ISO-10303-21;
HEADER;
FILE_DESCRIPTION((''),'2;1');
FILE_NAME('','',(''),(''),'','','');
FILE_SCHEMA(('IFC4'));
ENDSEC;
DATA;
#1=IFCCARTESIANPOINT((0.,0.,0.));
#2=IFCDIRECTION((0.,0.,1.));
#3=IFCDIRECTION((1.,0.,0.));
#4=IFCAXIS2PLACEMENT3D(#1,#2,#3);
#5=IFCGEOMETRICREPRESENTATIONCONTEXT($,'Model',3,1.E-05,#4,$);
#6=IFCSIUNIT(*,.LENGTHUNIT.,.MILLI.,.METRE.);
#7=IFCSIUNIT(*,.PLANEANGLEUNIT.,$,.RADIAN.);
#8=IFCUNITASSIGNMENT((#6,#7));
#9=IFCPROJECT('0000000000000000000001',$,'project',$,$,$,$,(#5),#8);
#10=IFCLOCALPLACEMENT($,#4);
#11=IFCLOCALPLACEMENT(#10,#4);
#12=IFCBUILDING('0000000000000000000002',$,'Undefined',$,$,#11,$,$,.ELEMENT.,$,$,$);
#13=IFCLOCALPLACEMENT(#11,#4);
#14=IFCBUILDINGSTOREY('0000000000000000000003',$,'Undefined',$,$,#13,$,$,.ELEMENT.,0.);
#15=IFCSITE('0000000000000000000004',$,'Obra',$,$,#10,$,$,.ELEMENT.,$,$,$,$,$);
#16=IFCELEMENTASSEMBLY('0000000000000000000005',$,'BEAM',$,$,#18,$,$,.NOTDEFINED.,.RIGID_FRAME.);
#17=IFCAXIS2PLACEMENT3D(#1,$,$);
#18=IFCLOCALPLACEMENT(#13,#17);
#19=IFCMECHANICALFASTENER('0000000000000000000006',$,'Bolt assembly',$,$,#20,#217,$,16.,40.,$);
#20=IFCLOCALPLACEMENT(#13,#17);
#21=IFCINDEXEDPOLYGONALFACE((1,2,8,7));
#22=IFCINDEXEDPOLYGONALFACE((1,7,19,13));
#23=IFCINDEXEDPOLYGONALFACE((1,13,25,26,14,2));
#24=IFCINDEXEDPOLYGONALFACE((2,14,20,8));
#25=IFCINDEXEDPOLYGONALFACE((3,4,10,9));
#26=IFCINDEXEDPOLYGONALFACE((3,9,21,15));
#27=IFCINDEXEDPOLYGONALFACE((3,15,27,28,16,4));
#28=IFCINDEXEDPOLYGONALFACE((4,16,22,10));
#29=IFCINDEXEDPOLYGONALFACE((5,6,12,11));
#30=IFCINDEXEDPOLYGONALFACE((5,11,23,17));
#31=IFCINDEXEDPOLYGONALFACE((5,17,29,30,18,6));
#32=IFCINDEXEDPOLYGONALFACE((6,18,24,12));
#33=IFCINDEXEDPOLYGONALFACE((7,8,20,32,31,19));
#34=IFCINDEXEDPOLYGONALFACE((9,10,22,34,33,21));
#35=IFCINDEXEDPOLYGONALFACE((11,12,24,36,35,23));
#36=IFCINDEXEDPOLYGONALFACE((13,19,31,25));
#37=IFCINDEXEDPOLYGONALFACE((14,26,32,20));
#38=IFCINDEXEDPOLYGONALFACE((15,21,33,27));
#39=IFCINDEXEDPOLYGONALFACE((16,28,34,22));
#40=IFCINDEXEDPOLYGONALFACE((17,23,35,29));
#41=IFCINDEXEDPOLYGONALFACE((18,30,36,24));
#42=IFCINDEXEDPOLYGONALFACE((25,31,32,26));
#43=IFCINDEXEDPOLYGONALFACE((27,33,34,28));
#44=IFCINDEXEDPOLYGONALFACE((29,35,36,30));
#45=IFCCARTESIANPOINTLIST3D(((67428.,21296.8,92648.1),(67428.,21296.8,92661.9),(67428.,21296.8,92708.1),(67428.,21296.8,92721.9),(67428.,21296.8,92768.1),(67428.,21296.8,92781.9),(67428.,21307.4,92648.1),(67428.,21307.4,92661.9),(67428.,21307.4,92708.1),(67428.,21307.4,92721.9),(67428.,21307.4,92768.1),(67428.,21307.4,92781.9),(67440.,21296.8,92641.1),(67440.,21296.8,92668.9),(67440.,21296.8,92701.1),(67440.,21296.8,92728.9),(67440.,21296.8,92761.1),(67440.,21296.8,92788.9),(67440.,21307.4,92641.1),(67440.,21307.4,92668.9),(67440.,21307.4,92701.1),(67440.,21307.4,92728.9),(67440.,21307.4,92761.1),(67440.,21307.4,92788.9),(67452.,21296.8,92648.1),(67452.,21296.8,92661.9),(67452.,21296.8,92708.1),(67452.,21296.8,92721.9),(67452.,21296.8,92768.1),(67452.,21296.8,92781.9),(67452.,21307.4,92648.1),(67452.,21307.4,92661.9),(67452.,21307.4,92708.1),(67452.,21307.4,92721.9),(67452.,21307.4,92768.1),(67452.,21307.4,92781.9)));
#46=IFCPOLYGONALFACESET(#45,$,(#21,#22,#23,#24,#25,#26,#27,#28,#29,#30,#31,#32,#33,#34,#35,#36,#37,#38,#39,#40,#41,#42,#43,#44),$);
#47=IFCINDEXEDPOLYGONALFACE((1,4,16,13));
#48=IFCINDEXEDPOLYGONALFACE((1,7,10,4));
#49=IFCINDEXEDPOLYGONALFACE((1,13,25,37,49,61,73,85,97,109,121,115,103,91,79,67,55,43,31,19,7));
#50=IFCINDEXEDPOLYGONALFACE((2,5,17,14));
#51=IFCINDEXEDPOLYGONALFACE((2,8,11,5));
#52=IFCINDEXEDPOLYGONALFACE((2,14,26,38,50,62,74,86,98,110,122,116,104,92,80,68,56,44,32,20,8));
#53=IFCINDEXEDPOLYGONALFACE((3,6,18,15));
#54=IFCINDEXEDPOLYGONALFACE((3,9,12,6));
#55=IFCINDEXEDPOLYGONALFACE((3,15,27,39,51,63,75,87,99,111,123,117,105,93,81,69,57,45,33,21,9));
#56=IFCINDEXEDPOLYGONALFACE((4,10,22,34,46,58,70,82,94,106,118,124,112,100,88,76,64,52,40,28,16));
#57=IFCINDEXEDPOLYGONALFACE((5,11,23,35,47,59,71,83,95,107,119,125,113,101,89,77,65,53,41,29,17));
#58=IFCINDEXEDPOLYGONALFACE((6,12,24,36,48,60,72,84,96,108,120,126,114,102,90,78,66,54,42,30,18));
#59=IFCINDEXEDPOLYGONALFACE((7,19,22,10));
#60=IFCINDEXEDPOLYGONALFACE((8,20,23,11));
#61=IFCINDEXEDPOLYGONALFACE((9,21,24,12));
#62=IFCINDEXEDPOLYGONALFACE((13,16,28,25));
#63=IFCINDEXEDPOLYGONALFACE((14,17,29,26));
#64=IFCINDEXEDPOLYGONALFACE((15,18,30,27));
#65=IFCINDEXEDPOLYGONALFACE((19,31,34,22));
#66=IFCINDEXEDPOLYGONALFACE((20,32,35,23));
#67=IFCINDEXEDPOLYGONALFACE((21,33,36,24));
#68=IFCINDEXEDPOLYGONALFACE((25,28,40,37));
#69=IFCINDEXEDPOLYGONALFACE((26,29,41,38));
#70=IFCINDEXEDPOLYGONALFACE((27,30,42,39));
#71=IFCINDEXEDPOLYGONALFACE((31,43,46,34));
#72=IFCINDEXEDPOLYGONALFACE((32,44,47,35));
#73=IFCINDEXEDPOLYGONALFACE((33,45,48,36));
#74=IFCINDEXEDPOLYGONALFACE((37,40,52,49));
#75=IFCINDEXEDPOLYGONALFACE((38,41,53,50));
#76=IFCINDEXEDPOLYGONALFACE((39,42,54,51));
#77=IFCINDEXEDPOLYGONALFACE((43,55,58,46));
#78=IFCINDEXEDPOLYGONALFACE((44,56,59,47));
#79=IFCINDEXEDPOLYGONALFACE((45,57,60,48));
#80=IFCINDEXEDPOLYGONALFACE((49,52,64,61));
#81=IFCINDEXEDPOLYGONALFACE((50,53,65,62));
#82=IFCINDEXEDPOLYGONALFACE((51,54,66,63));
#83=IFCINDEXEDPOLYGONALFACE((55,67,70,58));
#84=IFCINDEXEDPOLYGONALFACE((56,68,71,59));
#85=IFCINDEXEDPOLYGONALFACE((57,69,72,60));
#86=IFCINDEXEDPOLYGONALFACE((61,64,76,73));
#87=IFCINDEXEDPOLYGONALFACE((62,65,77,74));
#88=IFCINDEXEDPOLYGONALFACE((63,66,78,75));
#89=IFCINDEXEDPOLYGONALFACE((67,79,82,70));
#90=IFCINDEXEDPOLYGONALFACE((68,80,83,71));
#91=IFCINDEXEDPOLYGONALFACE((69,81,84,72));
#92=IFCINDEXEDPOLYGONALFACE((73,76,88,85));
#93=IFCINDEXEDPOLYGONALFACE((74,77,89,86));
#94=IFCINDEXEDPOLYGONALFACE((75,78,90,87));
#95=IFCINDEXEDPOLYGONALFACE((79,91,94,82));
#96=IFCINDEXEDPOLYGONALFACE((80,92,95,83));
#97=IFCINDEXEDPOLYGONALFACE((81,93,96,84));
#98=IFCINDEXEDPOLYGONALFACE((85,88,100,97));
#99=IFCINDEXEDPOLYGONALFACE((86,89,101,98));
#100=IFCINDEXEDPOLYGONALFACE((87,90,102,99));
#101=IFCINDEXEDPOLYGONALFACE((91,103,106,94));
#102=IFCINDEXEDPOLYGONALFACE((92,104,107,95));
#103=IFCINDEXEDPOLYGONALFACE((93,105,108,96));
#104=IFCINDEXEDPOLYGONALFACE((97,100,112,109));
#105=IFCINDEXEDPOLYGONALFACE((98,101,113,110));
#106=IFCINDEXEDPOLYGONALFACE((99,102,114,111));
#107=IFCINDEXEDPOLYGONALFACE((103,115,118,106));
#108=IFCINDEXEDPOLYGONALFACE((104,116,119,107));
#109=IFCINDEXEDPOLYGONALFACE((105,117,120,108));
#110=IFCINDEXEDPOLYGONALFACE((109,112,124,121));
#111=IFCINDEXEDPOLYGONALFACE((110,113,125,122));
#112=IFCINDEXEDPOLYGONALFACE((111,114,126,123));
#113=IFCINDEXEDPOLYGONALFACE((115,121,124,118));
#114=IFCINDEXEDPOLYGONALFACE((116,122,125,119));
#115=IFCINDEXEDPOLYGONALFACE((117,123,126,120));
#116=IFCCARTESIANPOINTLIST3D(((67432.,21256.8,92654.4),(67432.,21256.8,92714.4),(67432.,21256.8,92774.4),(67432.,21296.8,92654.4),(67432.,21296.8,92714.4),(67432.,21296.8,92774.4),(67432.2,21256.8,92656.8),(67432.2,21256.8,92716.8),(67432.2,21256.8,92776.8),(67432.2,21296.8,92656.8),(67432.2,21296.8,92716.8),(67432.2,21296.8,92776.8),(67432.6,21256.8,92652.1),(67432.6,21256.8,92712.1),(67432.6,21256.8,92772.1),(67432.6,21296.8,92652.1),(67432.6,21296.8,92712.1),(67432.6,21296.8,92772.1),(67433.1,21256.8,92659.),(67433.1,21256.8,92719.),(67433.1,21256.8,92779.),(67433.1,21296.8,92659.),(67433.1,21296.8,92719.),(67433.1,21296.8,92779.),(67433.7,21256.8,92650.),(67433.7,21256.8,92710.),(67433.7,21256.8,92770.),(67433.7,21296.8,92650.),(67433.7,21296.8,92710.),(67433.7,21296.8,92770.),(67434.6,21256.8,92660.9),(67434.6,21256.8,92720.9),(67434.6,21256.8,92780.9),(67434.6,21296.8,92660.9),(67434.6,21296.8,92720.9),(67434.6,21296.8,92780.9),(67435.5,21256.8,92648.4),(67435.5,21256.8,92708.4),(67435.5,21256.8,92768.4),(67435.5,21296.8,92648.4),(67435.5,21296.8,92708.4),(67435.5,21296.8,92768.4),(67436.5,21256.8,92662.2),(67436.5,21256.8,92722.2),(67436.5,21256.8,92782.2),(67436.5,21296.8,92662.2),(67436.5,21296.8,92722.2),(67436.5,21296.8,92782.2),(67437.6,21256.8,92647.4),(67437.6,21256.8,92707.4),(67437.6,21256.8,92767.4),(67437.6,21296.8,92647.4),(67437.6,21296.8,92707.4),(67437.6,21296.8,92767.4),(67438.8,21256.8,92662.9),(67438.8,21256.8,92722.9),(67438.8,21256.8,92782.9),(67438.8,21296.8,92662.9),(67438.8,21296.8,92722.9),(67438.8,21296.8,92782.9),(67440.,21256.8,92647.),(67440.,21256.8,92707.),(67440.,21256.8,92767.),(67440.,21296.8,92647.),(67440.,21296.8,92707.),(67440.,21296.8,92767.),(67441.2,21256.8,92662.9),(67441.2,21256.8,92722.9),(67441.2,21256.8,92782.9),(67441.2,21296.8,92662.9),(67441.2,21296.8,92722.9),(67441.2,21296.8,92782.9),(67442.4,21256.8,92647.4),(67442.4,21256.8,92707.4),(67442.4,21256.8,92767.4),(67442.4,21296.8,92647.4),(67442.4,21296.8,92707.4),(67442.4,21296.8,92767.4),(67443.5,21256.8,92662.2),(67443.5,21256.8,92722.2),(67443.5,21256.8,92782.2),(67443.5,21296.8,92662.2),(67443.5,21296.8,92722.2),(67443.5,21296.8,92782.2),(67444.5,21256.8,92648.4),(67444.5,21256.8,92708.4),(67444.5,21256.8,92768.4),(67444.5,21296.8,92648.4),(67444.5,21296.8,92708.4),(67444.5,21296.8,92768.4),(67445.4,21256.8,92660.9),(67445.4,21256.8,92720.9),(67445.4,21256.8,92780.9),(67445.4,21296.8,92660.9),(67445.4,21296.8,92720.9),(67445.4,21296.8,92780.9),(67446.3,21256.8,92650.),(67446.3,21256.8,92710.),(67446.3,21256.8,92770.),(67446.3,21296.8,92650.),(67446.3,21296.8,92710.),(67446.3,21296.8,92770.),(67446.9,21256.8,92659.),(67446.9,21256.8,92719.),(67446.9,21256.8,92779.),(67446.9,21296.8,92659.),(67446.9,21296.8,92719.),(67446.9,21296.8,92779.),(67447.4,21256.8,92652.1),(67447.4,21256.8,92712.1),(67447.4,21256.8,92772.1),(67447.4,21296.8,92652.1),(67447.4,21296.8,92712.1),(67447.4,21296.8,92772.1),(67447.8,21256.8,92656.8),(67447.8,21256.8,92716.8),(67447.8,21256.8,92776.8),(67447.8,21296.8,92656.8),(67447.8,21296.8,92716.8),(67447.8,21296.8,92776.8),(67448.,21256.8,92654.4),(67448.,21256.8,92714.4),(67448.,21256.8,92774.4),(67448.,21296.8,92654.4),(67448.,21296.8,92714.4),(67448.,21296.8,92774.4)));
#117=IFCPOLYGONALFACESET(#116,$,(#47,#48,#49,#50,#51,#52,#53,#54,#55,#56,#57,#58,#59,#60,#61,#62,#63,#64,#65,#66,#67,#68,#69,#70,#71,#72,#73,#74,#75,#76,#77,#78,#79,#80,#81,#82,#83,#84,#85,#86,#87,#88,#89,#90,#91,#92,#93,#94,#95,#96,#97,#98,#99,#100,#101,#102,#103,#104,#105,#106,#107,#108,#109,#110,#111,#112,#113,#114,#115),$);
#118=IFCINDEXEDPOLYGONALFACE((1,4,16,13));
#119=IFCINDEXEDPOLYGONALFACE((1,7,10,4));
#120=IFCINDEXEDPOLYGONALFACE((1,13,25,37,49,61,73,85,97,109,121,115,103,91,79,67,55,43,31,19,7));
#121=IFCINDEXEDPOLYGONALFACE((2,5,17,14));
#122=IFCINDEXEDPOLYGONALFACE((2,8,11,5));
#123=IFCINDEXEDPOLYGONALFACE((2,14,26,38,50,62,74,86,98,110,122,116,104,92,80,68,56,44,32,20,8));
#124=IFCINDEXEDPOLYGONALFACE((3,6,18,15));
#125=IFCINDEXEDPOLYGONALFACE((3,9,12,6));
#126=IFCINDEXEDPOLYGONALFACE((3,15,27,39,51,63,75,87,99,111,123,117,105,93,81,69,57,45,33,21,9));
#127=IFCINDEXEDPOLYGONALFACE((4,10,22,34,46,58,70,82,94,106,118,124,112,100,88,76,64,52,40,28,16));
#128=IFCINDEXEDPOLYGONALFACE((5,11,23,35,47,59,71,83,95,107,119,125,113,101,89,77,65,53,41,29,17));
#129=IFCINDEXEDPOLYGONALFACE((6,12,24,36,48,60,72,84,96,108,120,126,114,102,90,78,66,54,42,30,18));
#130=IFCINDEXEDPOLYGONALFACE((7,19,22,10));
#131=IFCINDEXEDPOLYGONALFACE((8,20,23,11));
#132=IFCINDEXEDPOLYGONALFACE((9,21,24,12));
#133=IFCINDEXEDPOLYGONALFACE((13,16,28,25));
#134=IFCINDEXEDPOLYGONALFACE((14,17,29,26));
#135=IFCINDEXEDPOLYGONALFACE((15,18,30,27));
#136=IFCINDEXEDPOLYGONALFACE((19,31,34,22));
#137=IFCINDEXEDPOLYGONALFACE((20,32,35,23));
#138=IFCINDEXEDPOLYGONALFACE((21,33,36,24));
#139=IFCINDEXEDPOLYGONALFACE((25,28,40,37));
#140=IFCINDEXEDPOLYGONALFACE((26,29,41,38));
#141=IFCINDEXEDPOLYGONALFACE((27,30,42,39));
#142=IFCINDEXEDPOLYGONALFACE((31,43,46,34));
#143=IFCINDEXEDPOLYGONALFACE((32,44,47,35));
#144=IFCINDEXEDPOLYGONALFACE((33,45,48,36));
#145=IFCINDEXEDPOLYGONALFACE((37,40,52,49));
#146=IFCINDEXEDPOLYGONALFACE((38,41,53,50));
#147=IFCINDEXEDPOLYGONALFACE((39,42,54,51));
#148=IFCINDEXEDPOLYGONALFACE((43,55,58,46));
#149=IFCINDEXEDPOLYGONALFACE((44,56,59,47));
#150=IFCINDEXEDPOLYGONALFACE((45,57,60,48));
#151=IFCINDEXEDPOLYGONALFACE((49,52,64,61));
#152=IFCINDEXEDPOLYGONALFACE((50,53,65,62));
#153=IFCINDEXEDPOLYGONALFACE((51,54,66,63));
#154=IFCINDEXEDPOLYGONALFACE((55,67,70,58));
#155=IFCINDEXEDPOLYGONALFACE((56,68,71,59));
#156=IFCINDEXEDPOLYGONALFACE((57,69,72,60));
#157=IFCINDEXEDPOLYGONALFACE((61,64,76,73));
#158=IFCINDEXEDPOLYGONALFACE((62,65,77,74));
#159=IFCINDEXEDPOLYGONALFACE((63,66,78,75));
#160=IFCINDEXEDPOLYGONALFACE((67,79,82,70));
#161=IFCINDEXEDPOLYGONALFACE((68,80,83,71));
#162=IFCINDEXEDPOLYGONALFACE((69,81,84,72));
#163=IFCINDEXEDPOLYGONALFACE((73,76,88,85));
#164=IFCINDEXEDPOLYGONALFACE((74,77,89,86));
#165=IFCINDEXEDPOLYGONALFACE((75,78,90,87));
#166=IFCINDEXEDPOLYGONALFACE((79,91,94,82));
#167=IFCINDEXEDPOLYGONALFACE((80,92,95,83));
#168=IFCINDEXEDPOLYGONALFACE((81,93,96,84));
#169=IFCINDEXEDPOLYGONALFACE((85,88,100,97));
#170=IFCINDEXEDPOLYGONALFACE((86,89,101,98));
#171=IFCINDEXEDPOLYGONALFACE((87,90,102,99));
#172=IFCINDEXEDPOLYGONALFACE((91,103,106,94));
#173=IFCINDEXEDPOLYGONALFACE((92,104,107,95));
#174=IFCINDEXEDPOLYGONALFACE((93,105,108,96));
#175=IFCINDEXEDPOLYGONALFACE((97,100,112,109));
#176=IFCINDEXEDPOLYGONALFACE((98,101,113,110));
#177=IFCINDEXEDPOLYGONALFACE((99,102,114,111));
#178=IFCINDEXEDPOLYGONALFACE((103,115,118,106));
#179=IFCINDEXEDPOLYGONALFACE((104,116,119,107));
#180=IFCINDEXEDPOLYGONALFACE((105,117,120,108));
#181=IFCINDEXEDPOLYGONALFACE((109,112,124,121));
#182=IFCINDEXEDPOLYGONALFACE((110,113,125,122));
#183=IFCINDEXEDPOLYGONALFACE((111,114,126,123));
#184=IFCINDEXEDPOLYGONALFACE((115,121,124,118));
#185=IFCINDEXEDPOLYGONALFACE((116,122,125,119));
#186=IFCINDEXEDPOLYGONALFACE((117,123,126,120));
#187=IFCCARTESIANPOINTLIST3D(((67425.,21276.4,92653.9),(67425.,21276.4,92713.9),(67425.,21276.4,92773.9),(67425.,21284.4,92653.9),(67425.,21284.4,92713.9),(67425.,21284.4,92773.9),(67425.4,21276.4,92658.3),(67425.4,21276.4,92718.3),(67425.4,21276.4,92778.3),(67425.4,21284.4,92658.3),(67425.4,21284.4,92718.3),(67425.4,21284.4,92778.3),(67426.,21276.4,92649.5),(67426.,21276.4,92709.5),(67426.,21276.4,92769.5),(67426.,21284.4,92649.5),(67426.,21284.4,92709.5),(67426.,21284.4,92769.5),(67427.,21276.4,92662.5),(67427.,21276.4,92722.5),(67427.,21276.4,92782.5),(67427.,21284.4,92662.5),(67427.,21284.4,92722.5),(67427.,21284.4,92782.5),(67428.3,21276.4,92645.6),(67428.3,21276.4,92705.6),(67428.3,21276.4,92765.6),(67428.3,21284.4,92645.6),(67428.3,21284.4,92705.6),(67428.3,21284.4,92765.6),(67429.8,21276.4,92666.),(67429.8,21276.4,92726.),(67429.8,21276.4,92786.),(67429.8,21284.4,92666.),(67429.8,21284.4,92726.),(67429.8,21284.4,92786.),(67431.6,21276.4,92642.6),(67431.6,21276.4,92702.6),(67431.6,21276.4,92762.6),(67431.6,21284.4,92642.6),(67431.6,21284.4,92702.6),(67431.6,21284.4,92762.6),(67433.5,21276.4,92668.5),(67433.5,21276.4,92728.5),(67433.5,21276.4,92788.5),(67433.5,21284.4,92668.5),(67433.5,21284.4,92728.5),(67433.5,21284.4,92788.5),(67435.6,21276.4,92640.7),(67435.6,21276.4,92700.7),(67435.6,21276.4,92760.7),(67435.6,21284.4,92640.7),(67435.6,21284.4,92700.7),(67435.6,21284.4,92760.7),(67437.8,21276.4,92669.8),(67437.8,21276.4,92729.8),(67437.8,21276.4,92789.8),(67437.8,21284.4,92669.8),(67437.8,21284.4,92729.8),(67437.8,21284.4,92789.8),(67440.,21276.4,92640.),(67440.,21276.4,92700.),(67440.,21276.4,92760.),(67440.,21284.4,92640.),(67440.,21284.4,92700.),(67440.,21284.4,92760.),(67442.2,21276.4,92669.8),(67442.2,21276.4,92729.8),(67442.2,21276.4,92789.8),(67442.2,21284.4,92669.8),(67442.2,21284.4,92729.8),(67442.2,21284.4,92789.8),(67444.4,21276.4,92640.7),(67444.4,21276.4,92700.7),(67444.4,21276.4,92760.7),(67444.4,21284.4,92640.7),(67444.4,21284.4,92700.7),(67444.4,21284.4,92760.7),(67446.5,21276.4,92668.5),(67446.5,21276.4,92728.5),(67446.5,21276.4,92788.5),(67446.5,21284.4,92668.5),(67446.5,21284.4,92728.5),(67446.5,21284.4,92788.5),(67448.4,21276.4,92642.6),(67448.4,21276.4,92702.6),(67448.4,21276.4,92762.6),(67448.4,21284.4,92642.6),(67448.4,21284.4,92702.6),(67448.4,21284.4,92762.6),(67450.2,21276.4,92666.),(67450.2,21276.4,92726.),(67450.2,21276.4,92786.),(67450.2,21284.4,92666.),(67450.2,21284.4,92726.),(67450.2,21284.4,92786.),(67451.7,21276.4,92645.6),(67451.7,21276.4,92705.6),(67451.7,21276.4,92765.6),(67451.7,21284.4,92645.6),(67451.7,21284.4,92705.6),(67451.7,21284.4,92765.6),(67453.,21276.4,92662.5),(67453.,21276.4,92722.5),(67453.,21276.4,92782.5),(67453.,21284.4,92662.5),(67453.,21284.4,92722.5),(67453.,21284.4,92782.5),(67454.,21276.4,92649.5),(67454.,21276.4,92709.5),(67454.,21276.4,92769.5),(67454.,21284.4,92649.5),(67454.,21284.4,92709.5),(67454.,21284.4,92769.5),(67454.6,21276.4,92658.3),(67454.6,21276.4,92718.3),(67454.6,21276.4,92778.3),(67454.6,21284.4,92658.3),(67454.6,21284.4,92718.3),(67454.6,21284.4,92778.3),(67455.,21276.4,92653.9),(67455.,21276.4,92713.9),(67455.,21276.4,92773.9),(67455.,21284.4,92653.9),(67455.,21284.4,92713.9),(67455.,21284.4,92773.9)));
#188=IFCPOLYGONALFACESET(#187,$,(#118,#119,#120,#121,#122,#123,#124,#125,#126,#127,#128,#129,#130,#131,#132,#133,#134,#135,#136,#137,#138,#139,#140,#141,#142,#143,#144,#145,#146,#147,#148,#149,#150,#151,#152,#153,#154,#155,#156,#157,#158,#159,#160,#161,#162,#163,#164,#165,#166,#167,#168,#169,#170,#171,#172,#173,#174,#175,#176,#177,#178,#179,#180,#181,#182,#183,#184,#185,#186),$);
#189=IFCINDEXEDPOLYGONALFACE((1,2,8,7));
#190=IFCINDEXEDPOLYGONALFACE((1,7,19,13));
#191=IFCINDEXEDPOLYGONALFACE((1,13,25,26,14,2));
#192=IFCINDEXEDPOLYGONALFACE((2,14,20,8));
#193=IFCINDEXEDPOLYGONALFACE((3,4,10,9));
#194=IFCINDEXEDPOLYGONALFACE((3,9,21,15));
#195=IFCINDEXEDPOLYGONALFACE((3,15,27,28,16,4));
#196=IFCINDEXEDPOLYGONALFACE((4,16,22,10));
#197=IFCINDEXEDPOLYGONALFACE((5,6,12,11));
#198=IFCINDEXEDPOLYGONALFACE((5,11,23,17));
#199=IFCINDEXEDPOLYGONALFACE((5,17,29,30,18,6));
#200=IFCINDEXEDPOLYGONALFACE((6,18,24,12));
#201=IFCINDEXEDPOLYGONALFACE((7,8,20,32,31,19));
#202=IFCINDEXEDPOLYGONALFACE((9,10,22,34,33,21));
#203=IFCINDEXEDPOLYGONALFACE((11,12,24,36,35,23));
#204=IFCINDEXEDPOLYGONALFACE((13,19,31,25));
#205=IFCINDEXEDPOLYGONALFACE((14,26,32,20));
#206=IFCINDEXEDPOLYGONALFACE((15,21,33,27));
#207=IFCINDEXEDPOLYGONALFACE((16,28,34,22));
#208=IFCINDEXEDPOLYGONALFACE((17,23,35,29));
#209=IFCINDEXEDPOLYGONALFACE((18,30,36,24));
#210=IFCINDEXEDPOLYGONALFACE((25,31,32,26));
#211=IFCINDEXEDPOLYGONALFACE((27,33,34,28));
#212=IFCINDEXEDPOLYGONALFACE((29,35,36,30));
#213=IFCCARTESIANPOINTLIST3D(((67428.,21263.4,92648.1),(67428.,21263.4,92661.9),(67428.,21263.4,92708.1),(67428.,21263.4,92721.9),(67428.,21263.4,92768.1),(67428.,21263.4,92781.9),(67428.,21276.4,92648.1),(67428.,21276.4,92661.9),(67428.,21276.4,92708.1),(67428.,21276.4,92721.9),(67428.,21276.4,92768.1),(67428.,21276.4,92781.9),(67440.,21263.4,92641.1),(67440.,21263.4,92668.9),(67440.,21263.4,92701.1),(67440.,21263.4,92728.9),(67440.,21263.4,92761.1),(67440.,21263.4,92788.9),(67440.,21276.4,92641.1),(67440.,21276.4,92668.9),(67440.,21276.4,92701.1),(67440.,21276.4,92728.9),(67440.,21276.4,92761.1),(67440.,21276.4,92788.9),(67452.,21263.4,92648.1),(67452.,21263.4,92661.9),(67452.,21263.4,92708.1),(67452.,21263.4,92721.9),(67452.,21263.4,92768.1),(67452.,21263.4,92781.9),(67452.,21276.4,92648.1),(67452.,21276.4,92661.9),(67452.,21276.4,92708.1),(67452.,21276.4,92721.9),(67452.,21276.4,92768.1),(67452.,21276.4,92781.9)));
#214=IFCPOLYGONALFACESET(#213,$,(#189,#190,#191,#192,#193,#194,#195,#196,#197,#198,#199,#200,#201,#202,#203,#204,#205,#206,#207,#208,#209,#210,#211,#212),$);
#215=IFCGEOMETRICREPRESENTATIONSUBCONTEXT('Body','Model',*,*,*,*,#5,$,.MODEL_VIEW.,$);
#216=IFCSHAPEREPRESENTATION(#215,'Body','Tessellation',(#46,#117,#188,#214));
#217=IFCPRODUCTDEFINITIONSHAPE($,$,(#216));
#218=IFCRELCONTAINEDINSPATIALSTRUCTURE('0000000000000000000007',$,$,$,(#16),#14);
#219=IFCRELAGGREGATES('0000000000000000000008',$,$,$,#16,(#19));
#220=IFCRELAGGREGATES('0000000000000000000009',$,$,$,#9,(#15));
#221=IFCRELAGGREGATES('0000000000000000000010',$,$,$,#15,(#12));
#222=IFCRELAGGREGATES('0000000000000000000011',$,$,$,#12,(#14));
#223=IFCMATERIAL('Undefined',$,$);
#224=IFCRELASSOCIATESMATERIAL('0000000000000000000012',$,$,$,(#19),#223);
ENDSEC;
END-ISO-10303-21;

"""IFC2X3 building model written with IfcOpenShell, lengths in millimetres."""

from ifc_helpers import new_model, si_unit, frame, origin_with_axes, origin_2d_with_axis, place, context, subcontext, project, spatial, polyline, circle, outline, extrude, source, transform, mapped, material, element, aggregate, save


model = new_model("IFC2X3")

# Units and contexts
model_context = context("Model", 3, precision=1e-05, world=origin_with_axes())
body_context = subcontext(model_context, "Body", "Model", "MODEL_VIEW")
ifc_project = project(units=[si_unit("LENGTHUNIT", "METRE", prefix="MILLI"), si_unit("PLANEANGLEUNIT", "RADIAN")], contexts=[model_context])

# Site, building, storey
site_placement = place(None, origin_with_axes())
site = spatial("IfcSite", under=ifc_project, at=site_placement, Name="Obra", CompositionType="ELEMENT")
building_placement = place(site_placement, origin_with_axes())
building = spatial("IfcBuilding", under=site, at=building_placement, Name="Undefined", CompositionType="ELEMENT")
storey_placement = place(building_placement, origin_with_axes())
storey = spatial("IfcBuildingStorey", under=building, at=storey_placement, Name="Undefined", CompositionType="ELEMENT", Elevation=0.0)

# Shared definitions
ifc_material_1 = material(Name="Undefined")

# Element assembly, mechanical fastener
shared_shape_1 = source(origin_with_axes(), body_context, "Body", "SweptSolid", [
    extrude(outline(polyline([(13.9, 0.0), (6.9, 12.0), (-6.9, 12.0), (-13.9, 0.0), (-6.9, -12.0), (6.9, -12.0), (13.9, 0.0)])), frame((0.0, -19.7, 0.0), z_axis=(0.0, 1.0, 0.0), x_axis=(1.0, 0.0, 0.0)), (0.0, 0.0, 1.0), 10.6),
    extrude(circle(Radius=8.0, at=origin_2d_with_axis()), frame((0.0, -9.1, 0.0), z_axis=(0.0, 1.0, 0.0), x_axis=(1.0, 0.0, 0.0)), (0.0, 0.0, 1.0), 40.0),
    extrude(circle(Radius=15.0, at=origin_2d_with_axis()), frame((0.0, 3.3, 0.0), z_axis=(0.0, 1.0, 0.0), x_axis=(1.0, 0.0, 0.0)), (0.0, 0.0, 1.0), 8.0),
    extrude(outline(polyline([(13.9, 0.0), (6.9, 12.0), (-6.9, 12.0), (-13.9, 0.0), (-6.9, -12.0), (6.9, -12.0), (13.9, 0.0)])), frame((0.0, 11.3, 0.0), z_axis=(0.0, 1.0, 0.0), x_axis=(1.0, 0.0, 0.0)), (0.0, 0.0, 1.0), 13.0),
])
assembly_1_placement = place(storey_placement, origin_with_axes())
assembly_1 = element("IfcElementAssembly", 1, at=assembly_1_placement, inside=storey, Name="BEAM", AssemblyPlace="NOTDEFINED", PredefinedType="RIGID_FRAME")
mechanical_fastener_1_placement = place(assembly_1_placement, frame((67490.0, 21287.7, 92835.0), z_axis=(-1.0, 0.0, 0.0), x_axis=(0.0, 0.0, -1.0)))
mechanical_fastener_1 = element("IfcMechanicalFastener", 2, at=mechanical_fastener_1_placement, material=ifc_material_1, Name="Bolt assembly", NominalDiameter=16.0, NominalLength=40.0, context=body_context, shape_type="MappedRepresentation", body=[
    mapped(shared_shape_1, transform((60.0, 0.0, 50.0))),
    mapped(shared_shape_1, transform((120.0, 0.0, 50.0))),
    mapped(shared_shape_1, transform((180.0, 0.0, 50.0))),
])
aggregate(assembly_1, [mechanical_fastener_1])

save(model, "model.ifc")
